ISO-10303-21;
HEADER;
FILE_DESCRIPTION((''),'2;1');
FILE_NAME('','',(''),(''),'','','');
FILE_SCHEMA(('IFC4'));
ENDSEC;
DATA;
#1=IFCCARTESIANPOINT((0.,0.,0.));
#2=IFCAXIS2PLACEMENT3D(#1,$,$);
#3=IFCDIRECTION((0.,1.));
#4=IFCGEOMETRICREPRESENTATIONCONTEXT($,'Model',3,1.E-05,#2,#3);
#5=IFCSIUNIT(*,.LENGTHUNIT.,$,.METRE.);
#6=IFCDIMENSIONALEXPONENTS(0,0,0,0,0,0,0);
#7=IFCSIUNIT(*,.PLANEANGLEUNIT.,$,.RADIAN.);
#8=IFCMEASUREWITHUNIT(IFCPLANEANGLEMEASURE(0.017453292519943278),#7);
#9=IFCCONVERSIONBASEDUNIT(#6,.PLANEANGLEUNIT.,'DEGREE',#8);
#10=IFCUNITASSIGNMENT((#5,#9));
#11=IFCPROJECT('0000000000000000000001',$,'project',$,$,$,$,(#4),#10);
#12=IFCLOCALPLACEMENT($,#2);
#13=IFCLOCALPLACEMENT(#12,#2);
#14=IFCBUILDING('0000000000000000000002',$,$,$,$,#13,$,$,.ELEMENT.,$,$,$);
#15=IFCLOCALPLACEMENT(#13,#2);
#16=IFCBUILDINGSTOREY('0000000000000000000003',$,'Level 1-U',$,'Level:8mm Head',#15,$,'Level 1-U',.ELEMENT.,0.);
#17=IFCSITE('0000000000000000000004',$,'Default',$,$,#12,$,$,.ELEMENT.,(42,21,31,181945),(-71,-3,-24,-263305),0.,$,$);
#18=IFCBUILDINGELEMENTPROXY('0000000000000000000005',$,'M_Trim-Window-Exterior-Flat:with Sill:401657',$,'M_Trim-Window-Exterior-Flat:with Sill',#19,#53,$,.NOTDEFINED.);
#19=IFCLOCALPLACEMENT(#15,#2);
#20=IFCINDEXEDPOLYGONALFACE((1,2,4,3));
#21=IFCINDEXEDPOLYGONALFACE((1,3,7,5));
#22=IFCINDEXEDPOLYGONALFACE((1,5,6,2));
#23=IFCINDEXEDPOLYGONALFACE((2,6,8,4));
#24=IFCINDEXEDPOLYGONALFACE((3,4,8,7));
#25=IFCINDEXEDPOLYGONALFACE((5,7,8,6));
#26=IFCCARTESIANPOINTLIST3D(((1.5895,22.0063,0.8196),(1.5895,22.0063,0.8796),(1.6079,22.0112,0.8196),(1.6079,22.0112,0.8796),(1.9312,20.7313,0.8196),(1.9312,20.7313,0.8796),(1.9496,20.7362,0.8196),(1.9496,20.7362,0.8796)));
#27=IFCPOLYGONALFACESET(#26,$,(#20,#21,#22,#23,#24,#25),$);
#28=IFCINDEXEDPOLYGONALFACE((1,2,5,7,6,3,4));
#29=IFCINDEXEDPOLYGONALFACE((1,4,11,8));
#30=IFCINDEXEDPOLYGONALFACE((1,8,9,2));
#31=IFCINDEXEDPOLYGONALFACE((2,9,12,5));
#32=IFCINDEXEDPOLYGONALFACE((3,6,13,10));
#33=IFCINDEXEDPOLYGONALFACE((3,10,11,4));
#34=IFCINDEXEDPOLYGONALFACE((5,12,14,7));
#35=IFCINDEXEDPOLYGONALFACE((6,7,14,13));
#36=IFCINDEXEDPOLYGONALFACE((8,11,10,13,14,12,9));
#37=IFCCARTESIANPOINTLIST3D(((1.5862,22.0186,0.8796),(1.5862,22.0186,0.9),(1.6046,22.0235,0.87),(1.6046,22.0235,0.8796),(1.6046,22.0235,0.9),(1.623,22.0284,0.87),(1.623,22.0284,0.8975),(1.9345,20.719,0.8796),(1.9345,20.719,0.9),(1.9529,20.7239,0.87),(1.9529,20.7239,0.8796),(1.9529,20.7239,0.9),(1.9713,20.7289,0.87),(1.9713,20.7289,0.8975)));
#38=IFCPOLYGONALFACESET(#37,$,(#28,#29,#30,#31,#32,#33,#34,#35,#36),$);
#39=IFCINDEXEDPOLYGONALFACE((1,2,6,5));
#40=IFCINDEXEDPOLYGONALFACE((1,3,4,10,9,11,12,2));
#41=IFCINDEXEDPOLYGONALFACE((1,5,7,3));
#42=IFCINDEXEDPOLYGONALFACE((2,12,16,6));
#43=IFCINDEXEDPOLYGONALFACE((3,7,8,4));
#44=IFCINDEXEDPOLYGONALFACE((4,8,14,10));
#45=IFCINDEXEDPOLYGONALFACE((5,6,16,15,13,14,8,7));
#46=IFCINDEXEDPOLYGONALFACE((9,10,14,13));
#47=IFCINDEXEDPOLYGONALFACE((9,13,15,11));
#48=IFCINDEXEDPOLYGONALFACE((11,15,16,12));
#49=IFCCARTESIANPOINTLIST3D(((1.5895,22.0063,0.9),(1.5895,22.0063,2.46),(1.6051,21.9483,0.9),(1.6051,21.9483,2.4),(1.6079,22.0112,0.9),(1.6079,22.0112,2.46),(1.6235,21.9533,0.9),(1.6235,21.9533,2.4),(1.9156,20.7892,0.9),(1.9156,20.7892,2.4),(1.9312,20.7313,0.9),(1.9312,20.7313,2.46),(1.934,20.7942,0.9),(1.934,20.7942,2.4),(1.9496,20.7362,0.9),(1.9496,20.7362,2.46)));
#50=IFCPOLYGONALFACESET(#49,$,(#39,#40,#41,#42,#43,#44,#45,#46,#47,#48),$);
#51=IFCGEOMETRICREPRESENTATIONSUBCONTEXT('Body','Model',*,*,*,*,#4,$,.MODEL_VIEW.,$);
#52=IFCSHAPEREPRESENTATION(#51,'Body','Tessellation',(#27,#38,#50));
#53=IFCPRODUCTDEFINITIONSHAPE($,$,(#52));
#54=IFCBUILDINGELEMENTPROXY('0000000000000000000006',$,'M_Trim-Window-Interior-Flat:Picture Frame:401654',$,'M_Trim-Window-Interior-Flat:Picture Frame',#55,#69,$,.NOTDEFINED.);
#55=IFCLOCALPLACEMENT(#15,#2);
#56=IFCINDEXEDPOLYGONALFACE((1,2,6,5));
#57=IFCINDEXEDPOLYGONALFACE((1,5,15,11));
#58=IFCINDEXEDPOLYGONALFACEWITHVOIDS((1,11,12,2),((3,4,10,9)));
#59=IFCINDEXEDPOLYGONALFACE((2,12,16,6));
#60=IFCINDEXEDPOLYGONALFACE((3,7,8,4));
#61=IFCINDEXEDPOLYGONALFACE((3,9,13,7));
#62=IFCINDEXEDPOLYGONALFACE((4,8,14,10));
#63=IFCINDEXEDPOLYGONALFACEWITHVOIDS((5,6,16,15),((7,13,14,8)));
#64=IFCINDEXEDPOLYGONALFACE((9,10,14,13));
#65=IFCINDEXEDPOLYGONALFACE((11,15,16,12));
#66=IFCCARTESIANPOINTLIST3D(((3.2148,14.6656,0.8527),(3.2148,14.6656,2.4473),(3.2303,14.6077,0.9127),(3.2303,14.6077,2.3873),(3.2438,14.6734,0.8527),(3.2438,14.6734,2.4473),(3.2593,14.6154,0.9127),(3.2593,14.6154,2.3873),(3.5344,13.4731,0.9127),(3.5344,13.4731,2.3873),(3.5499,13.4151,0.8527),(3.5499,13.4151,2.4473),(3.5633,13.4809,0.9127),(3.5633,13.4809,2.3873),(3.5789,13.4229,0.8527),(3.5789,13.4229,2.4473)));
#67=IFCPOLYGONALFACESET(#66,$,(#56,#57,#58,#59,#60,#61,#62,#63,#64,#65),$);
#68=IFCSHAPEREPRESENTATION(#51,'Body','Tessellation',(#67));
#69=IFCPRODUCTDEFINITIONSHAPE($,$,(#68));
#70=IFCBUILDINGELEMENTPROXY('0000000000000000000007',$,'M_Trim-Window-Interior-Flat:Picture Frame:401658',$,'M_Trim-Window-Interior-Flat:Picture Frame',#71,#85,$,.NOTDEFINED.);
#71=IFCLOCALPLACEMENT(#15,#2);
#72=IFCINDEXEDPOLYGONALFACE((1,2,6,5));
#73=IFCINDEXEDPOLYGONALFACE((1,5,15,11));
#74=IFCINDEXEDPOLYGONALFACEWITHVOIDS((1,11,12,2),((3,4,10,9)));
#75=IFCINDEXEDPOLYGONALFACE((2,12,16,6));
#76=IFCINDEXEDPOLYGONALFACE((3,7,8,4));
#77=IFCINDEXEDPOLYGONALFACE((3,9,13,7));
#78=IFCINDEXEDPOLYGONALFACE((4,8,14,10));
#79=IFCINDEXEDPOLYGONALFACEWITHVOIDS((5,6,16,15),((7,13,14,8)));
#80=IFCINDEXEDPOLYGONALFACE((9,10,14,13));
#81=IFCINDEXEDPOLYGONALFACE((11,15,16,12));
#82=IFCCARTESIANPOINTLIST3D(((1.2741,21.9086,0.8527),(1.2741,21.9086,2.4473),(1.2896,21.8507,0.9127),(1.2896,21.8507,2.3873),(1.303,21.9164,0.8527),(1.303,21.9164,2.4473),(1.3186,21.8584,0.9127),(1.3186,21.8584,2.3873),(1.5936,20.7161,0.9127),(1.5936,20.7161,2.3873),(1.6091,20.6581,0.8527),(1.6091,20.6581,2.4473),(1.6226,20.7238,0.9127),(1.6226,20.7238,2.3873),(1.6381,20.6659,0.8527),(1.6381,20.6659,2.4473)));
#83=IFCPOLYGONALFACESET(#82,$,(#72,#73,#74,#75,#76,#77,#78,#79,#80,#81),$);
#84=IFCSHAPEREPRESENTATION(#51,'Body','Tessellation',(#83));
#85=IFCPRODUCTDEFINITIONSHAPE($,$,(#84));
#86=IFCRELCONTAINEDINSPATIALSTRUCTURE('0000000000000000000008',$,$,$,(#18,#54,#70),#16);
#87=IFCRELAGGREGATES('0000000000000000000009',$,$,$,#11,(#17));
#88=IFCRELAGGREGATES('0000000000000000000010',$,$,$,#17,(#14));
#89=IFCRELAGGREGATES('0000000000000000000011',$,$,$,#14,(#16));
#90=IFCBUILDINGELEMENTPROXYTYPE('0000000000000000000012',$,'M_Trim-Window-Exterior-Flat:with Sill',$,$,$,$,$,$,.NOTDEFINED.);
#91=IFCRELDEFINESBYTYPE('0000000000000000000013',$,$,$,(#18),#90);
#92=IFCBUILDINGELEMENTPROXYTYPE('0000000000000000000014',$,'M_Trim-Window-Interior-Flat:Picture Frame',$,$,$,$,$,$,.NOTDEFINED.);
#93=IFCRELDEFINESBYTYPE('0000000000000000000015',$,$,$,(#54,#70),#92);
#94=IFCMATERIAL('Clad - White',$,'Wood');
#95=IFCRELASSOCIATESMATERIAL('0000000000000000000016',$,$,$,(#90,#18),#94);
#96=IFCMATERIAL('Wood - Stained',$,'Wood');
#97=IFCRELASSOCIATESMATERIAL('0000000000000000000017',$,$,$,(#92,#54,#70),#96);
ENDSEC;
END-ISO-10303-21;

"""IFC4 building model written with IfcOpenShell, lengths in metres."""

from ifc_helpers import new_model, entity, si_unit, converted_unit, direction, frame, frame_2d, origin, place, context, subcontext, project, spatial, polyline, rectangle, outline, extrude, source, transform, mapped, material, type_object, type_shapes, element, save


model = new_model("IFC4")

# Units and contexts
model_context = context("Model", 3, precision=1e-05, world=origin(), true_north=direction((0.0, 1.0)))
body_context = subcontext(model_context, "Body", "Model", "MODEL_VIEW")
ifc_project = project(units=[si_unit("LENGTHUNIT", "METRE"), converted_unit("PLANEANGLEUNIT", "DEGREE", entity("IfcPlaneAngleMeasure", 0.017453292519943278), si_unit("PLANEANGLEUNIT", "RADIAN"), dimensions=[0, 0, 0, 0, 0, 0, 0])], contexts=[model_context])

# Site, building, storey
site_placement = place(None, origin())
site = spatial("IfcSite", under=ifc_project, at=site_placement, Name="Default", CompositionType="ELEMENT", RefLatitude=(42, 21, 31, 181945), RefLongitude=(-71, -3, -24, -263305), RefElevation=0.0)
building_placement = place(site_placement, origin())
building = spatial("IfcBuilding", under=site, at=building_placement, CompositionType="ELEMENT")
storey_placement = place(building_placement, origin())
storey = spatial("IfcBuildingStorey", under=building, at=storey_placement, Name="Level 1-U", ObjectType="Level:8mm Head", LongName="Level 1-U", CompositionType="ELEMENT", Elevation=0.0)

# Building element proxies
ifc_material_1 = material(Name="Clad - White", Category="Wood")
ifc_material_2 = material(Name="Wood - Stained", Category="Wood")
building_element_proxy_type_1 = type_object("IfcBuildingElementProxyType", Name="M_Trim-Window-Exterior-Flat:with Sill", PredefinedType="NOTDEFINED", material=ifc_material_1)
shared_shape_1 = source(origin(), body_context, "Body", "SweptSolid", [
    extrude(rectangle(XDim=1.32, YDim=0.06, at=frame_2d((0.0, 0.0), x_axis=(1.0, 0.0))), frame((0.0, -1.5504, 0.0), z_axis=(0.0, 0.0, 1.0), x_axis=(-1.0, 0.0, 0.0)), (0.0, 0.0, 1.0), 0.019),
    extrude(outline(polyline([(-0.019, -0.0152), (0.0, -0.0152), (0.0, -0.0057), (0.019, -0.0057), (0.019, 0.0148), (0.0, 0.0148), (-0.019, 0.0123), (-0.019, -0.0152)])), frame((-0.6727, -1.5148, 0.019), z_axis=(1.0, 0.0, 0.0), x_axis=(0.0, 0.0, -1.0)), (0.0, 0.0, 1.0), 1.3454),
    extrude(outline(polyline([(-0.795, -0.66), (0.765, -0.66), (0.765, -0.6), (-0.735, -0.6), (-0.735, 0.6), (0.765, 0.6), (0.765, 0.66), (-0.795, 0.66), (-0.795, -0.66)])), frame((0.0, -0.735, 0.0), z_axis=(0.0, 0.0, 1.0), x_axis=(0.0, -1.0, 0.0)), (0.0, 0.0, 1.0), 0.019),
])
type_shapes(building_element_proxy_type_1, [shared_shape_1])
for number, where, z_axis, x_axis, name in (
    (1, (1.7603, 21.3688, 2.4), (0.965926, 0.258819, 0.0), (-0.258819, 0.965926, 0.0), "M_Trim-Window-Exterior-Flat:with Sill:401657"),
):
    element("IfcBuildingElementProxy", number, at=place(storey_placement, frame(where, z_axis=z_axis, x_axis=x_axis)), inside=storey, type_object=building_element_proxy_type_1, material=ifc_material_1, Name=name, ObjectType="M_Trim-Window-Exterior-Flat:with Sill", PredefinedType="NOTDEFINED", context=body_context, shape_type="MappedRepresentation", body=[
        mapped(shared_shape_1, transform((0.0, 0.0, 0.0), scale=1.0)),
    ])
building_element_proxy_type_2 = type_object("IfcBuildingElementProxyType", Name="M_Trim-Window-Interior-Flat:Picture Frame", PredefinedType="NOTDEFINED", material=ifc_material_2)
shared_shape_2 = source(origin(), body_context, "Body", "SweptSolid", [
    extrude(outline(polyline([(-0.6473, -0.7973), (0.6473, -0.7973), (0.6473, 0.7973), (-0.6473, 0.7973), (-0.6473, -0.7973)]), holes=[polyline([(-0.5873, -0.7373), (-0.5873, 0.7373), (0.5873, 0.7373), (0.5873, -0.7373), (-0.5873, -0.7373)])]), frame((0.0, -0.75, 0.0), z_axis=(0.0, 0.0, 1.0), x_axis=(-1.0, 0.0, 0.0)), (0.0, 0.0, 1.0), 0.03),
])
type_shapes(building_element_proxy_type_2, [shared_shape_2])
for number, where, z_axis, x_axis, name in (
    (2, (3.4113, 14.0481, 2.4), (-0.965926, -0.258819, 0.0), (0.258819, -0.965926, 0.0), "M_Trim-Window-Interior-Flat:Picture Frame:401654"),
    (3, (1.4706, 21.2911, 2.4), (-0.965926, -0.258819, 0.0), (0.258819, -0.965926, 0.0), "M_Trim-Window-Interior-Flat:Picture Frame:401658"),
):
    element("IfcBuildingElementProxy", number, at=place(storey_placement, frame(where, z_axis=z_axis, x_axis=x_axis)), inside=storey, type_object=building_element_proxy_type_2, material=ifc_material_2, Name=name, ObjectType="M_Trim-Window-Interior-Flat:Picture Frame", PredefinedType="NOTDEFINED", context=body_context, shape_type="MappedRepresentation", body=[
        mapped(shared_shape_2, transform((0.0, 0.0, 0.0), scale=1.0)),
    ])

save(model, "model.ifc")
